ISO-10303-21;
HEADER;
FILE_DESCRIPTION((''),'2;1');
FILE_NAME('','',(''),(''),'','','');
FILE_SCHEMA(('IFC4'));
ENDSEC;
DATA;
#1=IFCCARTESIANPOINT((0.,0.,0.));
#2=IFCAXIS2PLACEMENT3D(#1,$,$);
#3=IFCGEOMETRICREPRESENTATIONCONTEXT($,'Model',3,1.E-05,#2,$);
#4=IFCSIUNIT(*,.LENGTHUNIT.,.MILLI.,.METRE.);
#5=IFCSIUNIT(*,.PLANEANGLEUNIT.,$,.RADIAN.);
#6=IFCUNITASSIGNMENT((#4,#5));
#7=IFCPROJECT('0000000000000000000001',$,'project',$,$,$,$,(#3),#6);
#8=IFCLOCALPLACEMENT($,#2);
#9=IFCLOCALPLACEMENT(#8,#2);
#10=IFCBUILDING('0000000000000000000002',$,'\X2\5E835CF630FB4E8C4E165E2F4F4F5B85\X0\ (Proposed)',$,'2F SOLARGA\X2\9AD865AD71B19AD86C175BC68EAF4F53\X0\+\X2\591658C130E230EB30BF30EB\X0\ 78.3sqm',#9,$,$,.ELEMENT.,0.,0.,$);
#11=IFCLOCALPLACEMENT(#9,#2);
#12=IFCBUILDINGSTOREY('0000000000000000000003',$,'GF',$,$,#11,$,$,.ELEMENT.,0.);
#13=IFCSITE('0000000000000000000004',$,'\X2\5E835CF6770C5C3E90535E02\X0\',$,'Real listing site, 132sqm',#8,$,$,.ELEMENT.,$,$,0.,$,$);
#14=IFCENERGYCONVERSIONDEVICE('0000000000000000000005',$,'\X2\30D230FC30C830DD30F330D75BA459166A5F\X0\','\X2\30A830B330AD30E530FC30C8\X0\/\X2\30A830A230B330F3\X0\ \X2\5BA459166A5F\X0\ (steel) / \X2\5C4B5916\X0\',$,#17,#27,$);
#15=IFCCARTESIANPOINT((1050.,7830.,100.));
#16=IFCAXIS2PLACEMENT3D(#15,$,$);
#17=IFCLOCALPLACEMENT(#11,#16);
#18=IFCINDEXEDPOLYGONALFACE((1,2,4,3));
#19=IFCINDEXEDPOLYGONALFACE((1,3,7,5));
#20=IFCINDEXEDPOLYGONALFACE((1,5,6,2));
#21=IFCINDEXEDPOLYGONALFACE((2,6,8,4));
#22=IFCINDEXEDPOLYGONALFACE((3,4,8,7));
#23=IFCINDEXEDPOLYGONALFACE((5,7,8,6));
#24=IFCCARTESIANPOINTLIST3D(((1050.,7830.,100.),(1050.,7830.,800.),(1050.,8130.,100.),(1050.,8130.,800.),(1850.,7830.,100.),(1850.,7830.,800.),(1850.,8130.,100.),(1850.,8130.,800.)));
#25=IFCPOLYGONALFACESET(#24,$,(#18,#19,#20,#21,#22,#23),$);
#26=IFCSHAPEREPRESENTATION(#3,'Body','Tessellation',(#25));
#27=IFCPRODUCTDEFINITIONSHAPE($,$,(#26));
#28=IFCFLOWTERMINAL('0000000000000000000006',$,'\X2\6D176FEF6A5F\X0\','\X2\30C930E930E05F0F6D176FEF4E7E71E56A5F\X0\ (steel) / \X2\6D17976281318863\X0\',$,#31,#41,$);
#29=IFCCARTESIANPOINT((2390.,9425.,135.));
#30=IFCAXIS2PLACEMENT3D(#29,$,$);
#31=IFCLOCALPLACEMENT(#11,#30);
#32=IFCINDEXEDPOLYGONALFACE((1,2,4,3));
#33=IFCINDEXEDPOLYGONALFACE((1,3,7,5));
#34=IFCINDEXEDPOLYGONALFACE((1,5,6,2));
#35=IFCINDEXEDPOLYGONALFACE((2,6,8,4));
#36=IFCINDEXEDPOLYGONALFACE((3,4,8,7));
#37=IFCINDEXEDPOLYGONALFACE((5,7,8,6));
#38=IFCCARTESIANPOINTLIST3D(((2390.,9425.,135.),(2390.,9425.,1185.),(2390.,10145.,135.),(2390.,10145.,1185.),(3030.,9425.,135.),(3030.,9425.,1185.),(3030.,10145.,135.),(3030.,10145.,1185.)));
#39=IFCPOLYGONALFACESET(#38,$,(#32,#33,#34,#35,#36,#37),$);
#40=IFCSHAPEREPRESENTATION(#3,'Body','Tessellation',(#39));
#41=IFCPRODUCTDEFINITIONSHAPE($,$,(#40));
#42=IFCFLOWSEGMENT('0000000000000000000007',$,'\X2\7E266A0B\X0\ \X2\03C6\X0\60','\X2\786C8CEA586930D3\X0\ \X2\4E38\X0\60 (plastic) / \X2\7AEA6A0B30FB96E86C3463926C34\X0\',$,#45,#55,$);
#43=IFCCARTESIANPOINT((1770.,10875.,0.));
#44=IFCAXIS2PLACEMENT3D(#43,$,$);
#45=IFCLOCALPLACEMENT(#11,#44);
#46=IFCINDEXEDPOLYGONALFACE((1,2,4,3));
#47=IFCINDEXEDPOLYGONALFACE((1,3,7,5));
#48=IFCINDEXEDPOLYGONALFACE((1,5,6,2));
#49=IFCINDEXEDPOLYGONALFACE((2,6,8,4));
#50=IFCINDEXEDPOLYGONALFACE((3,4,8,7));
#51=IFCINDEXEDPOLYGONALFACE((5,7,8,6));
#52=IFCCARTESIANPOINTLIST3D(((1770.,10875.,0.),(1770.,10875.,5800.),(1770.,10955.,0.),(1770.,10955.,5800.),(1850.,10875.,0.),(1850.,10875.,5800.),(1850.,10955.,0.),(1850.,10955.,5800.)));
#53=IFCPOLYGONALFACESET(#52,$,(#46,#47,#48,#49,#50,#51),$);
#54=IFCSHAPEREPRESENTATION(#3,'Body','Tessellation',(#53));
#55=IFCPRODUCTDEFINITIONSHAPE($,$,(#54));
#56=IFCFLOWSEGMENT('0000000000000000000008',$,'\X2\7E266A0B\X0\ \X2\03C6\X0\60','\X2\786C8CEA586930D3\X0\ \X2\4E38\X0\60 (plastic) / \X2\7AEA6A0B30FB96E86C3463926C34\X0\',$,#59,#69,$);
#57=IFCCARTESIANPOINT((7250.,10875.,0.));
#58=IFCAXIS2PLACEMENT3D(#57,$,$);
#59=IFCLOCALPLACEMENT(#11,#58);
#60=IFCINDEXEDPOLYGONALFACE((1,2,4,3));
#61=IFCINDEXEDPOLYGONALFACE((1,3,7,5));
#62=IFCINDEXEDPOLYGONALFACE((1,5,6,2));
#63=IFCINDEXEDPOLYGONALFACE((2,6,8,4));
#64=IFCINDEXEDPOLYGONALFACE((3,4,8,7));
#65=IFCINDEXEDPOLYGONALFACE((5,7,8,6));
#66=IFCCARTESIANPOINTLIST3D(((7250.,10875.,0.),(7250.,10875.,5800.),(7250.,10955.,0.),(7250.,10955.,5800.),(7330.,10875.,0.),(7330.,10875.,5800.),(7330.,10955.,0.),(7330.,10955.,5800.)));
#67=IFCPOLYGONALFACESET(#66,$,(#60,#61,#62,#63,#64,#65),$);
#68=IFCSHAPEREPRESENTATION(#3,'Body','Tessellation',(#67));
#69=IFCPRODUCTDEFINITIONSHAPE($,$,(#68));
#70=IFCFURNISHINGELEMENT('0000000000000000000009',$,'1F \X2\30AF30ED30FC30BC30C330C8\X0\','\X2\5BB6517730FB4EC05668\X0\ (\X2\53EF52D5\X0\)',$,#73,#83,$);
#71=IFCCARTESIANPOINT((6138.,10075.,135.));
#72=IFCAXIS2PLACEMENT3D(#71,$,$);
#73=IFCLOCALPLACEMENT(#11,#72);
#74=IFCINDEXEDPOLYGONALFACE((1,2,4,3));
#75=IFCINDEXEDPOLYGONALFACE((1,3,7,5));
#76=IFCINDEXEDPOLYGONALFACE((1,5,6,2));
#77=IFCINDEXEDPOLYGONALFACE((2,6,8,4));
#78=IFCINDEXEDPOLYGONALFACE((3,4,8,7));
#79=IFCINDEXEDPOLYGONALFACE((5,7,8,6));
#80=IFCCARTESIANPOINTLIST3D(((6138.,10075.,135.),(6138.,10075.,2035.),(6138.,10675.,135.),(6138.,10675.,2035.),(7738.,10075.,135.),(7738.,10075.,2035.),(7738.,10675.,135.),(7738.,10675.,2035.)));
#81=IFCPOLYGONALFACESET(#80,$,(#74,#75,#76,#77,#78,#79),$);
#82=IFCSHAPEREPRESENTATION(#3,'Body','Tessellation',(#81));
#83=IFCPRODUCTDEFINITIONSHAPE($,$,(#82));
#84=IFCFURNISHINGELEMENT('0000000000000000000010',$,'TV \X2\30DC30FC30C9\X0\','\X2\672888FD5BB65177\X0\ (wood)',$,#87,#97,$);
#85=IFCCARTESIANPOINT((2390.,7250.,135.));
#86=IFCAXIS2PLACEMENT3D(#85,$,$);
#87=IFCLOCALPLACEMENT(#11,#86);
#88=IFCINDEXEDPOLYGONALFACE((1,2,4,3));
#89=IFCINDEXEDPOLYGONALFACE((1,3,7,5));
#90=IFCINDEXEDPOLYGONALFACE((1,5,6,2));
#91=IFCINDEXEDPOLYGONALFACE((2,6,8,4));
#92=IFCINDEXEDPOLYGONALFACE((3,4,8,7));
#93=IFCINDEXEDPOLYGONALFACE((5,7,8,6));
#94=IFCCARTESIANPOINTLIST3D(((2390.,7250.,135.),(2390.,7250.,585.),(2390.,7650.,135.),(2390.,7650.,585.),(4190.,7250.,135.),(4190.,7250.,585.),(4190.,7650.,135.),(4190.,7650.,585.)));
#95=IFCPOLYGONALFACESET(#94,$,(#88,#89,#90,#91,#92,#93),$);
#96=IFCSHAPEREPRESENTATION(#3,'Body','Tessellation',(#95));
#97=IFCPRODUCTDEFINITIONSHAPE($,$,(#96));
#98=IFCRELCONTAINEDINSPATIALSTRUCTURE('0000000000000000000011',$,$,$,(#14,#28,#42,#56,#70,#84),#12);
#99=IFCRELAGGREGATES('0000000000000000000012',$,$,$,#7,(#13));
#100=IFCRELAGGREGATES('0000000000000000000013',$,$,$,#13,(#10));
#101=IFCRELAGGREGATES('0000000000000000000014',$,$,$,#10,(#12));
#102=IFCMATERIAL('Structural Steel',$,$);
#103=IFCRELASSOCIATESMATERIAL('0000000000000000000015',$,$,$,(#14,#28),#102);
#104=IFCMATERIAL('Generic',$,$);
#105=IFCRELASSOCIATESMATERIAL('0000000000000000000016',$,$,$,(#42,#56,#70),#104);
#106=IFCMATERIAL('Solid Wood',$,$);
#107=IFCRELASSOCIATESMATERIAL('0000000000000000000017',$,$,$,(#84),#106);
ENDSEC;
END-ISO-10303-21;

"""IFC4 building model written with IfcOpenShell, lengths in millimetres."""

from ifc_helpers import new_model, si_unit, frame, frame_2d, origin, place, context, project, spatial, rectangle, extrude, material, element, save


model = new_model("IFC4")

# Units and contexts
model_context = context("Model", 3, precision=1e-05, world=origin())
ifc_project = project(units=[si_unit("LENGTHUNIT", "METRE", prefix="MILLI"), si_unit("PLANEANGLEUNIT", "RADIAN")], contexts=[model_context])

# Site, building, storey
site_placement = place(None, origin())
site = spatial("IfcSite", under=ifc_project, at=site_placement, Name="広島県尾道市", ObjectType="Real listing site, 132sqm", CompositionType="ELEMENT", RefElevation=0.0)
building_placement = place(site_placement, origin())
building = spatial("IfcBuilding", under=site, at=building_placement, Name="広島・二世帯住宅 (Proposed)", ObjectType="2F SOLARGA高断熱高気密躯体+外壁モルタル 78.3sqm", CompositionType="ELEMENT", ElevationOfRefHeight=0.0, ElevationOfTerrain=0.0)
storey_placement = place(building_placement, origin())
storey = spatial("IfcBuildingStorey", under=building, at=storey_placement, Name="GF", CompositionType="ELEMENT", Elevation=0.0)

# Shared definitions
ifc_material_1 = material(Name="Solid Wood")

# Shared definitions
ifc_material_2 = material(Name="Generic")

# Shared definitions
ifc_material_3 = material(Name="Structural Steel")

# Energy conversion device
energy_conversion_device_placement = place(storey_placement, frame((1050.0, 7830.0, 100.0)))
element("IfcEnergyConversionDevice", 1, at=energy_conversion_device_placement, inside=storey, material=ifc_material_3, Name="ヒートポンプ室外機", Description="エコキュート/エアコン 室外機 (steel) / 屋外", context=model_context, shape_type="SweptSolid", body=[
    extrude(rectangle(XDim=800.0, YDim=300.0, at=frame_2d((400.0, 150.0))), frame((1050.0, 7830.0, 100.0)), (0.0, 0.0, 1.0), 700.0),
])

# Flow terminal
flow_terminal_placement = place(storey_placement, frame((2390.0, 9425.0, 135.0)))
element("IfcFlowTerminal", 2, at=flow_terminal_placement, inside=storey, material=ifc_material_3, Name="洗濯機", Description="ドラム式洗濯乾燥機 (steel) / 洗面脱衣", context=model_context, shape_type="SweptSolid", body=[
    extrude(rectangle(XDim=640.0, YDim=720.0, at=frame_2d((320.0, 360.0))), frame((2390.0, 9425.0, 135.0)), (0.0, 0.0, 1.0), 1050.0),
])

# Flow segments
flow_segment_1_placement = place(storey_placement, frame((1770.0, 10875.0, 0.0)))
element("IfcFlowSegment", 3, at=flow_segment_1_placement, inside=storey, material=ifc_material_2, Name="縦樋 φ60", Description="硬質塩ビ 丸60 (plastic) / 竪樋・雨水排水", context=model_context, shape_type="SweptSolid", body=[
    extrude(rectangle(XDim=80.0, YDim=80.0, at=frame_2d((40.0, 40.0))), frame((1770.0, 10875.0, 0.0)), (0.0, 0.0, 1.0), 5800.0),
])
flow_segment_2_placement = place(storey_placement, frame((7250.0, 10875.0, 0.0)))
element("IfcFlowSegment", 4, at=flow_segment_2_placement, inside=storey, material=ifc_material_2, Name="縦樋 φ60", Description="硬質塩ビ 丸60 (plastic) / 竪樋・雨水排水", context=model_context, shape_type="SweptSolid", body=[
    extrude(rectangle(XDim=80.0, YDim=80.0, at=frame_2d((40.0, 40.0))), frame((7250.0, 10875.0, 0.0)), (0.0, 0.0, 1.0), 5800.0),
])

# Furnishing elements
furnishing_1_placement = place(storey_placement, frame((6138.0, 10075.0, 135.0)))
element("IfcFurnishingElement", 5, at=furnishing_1_placement, inside=storey, material=ifc_material_2, Name="1F クローゼット", Description="家具・什器 (可動)", context=model_context, shape_type="SweptSolid", body=[
    extrude(rectangle(XDim=1600.0, YDim=600.0, at=frame_2d((800.0, 300.0))), frame((6138.0, 10075.0, 135.0)), (0.0, 0.0, 1.0), 1900.0),
])
furnishing_2_placement = place(storey_placement, frame((2390.0, 7250.0, 135.0)))
element("IfcFurnishingElement", 6, at=furnishing_2_placement, inside=storey, material=ifc_material_1, Name="TV ボード", Description="木製家具 (wood)", context=model_context, shape_type="SweptSolid", body=[
    extrude(rectangle(XDim=1800.0, YDim=400.0, at=frame_2d((900.0, 200.0))), frame((2390.0, 7250.0, 135.0)), (0.0, 0.0, 1.0), 450.0),
])

save(model, "model.ifc")
